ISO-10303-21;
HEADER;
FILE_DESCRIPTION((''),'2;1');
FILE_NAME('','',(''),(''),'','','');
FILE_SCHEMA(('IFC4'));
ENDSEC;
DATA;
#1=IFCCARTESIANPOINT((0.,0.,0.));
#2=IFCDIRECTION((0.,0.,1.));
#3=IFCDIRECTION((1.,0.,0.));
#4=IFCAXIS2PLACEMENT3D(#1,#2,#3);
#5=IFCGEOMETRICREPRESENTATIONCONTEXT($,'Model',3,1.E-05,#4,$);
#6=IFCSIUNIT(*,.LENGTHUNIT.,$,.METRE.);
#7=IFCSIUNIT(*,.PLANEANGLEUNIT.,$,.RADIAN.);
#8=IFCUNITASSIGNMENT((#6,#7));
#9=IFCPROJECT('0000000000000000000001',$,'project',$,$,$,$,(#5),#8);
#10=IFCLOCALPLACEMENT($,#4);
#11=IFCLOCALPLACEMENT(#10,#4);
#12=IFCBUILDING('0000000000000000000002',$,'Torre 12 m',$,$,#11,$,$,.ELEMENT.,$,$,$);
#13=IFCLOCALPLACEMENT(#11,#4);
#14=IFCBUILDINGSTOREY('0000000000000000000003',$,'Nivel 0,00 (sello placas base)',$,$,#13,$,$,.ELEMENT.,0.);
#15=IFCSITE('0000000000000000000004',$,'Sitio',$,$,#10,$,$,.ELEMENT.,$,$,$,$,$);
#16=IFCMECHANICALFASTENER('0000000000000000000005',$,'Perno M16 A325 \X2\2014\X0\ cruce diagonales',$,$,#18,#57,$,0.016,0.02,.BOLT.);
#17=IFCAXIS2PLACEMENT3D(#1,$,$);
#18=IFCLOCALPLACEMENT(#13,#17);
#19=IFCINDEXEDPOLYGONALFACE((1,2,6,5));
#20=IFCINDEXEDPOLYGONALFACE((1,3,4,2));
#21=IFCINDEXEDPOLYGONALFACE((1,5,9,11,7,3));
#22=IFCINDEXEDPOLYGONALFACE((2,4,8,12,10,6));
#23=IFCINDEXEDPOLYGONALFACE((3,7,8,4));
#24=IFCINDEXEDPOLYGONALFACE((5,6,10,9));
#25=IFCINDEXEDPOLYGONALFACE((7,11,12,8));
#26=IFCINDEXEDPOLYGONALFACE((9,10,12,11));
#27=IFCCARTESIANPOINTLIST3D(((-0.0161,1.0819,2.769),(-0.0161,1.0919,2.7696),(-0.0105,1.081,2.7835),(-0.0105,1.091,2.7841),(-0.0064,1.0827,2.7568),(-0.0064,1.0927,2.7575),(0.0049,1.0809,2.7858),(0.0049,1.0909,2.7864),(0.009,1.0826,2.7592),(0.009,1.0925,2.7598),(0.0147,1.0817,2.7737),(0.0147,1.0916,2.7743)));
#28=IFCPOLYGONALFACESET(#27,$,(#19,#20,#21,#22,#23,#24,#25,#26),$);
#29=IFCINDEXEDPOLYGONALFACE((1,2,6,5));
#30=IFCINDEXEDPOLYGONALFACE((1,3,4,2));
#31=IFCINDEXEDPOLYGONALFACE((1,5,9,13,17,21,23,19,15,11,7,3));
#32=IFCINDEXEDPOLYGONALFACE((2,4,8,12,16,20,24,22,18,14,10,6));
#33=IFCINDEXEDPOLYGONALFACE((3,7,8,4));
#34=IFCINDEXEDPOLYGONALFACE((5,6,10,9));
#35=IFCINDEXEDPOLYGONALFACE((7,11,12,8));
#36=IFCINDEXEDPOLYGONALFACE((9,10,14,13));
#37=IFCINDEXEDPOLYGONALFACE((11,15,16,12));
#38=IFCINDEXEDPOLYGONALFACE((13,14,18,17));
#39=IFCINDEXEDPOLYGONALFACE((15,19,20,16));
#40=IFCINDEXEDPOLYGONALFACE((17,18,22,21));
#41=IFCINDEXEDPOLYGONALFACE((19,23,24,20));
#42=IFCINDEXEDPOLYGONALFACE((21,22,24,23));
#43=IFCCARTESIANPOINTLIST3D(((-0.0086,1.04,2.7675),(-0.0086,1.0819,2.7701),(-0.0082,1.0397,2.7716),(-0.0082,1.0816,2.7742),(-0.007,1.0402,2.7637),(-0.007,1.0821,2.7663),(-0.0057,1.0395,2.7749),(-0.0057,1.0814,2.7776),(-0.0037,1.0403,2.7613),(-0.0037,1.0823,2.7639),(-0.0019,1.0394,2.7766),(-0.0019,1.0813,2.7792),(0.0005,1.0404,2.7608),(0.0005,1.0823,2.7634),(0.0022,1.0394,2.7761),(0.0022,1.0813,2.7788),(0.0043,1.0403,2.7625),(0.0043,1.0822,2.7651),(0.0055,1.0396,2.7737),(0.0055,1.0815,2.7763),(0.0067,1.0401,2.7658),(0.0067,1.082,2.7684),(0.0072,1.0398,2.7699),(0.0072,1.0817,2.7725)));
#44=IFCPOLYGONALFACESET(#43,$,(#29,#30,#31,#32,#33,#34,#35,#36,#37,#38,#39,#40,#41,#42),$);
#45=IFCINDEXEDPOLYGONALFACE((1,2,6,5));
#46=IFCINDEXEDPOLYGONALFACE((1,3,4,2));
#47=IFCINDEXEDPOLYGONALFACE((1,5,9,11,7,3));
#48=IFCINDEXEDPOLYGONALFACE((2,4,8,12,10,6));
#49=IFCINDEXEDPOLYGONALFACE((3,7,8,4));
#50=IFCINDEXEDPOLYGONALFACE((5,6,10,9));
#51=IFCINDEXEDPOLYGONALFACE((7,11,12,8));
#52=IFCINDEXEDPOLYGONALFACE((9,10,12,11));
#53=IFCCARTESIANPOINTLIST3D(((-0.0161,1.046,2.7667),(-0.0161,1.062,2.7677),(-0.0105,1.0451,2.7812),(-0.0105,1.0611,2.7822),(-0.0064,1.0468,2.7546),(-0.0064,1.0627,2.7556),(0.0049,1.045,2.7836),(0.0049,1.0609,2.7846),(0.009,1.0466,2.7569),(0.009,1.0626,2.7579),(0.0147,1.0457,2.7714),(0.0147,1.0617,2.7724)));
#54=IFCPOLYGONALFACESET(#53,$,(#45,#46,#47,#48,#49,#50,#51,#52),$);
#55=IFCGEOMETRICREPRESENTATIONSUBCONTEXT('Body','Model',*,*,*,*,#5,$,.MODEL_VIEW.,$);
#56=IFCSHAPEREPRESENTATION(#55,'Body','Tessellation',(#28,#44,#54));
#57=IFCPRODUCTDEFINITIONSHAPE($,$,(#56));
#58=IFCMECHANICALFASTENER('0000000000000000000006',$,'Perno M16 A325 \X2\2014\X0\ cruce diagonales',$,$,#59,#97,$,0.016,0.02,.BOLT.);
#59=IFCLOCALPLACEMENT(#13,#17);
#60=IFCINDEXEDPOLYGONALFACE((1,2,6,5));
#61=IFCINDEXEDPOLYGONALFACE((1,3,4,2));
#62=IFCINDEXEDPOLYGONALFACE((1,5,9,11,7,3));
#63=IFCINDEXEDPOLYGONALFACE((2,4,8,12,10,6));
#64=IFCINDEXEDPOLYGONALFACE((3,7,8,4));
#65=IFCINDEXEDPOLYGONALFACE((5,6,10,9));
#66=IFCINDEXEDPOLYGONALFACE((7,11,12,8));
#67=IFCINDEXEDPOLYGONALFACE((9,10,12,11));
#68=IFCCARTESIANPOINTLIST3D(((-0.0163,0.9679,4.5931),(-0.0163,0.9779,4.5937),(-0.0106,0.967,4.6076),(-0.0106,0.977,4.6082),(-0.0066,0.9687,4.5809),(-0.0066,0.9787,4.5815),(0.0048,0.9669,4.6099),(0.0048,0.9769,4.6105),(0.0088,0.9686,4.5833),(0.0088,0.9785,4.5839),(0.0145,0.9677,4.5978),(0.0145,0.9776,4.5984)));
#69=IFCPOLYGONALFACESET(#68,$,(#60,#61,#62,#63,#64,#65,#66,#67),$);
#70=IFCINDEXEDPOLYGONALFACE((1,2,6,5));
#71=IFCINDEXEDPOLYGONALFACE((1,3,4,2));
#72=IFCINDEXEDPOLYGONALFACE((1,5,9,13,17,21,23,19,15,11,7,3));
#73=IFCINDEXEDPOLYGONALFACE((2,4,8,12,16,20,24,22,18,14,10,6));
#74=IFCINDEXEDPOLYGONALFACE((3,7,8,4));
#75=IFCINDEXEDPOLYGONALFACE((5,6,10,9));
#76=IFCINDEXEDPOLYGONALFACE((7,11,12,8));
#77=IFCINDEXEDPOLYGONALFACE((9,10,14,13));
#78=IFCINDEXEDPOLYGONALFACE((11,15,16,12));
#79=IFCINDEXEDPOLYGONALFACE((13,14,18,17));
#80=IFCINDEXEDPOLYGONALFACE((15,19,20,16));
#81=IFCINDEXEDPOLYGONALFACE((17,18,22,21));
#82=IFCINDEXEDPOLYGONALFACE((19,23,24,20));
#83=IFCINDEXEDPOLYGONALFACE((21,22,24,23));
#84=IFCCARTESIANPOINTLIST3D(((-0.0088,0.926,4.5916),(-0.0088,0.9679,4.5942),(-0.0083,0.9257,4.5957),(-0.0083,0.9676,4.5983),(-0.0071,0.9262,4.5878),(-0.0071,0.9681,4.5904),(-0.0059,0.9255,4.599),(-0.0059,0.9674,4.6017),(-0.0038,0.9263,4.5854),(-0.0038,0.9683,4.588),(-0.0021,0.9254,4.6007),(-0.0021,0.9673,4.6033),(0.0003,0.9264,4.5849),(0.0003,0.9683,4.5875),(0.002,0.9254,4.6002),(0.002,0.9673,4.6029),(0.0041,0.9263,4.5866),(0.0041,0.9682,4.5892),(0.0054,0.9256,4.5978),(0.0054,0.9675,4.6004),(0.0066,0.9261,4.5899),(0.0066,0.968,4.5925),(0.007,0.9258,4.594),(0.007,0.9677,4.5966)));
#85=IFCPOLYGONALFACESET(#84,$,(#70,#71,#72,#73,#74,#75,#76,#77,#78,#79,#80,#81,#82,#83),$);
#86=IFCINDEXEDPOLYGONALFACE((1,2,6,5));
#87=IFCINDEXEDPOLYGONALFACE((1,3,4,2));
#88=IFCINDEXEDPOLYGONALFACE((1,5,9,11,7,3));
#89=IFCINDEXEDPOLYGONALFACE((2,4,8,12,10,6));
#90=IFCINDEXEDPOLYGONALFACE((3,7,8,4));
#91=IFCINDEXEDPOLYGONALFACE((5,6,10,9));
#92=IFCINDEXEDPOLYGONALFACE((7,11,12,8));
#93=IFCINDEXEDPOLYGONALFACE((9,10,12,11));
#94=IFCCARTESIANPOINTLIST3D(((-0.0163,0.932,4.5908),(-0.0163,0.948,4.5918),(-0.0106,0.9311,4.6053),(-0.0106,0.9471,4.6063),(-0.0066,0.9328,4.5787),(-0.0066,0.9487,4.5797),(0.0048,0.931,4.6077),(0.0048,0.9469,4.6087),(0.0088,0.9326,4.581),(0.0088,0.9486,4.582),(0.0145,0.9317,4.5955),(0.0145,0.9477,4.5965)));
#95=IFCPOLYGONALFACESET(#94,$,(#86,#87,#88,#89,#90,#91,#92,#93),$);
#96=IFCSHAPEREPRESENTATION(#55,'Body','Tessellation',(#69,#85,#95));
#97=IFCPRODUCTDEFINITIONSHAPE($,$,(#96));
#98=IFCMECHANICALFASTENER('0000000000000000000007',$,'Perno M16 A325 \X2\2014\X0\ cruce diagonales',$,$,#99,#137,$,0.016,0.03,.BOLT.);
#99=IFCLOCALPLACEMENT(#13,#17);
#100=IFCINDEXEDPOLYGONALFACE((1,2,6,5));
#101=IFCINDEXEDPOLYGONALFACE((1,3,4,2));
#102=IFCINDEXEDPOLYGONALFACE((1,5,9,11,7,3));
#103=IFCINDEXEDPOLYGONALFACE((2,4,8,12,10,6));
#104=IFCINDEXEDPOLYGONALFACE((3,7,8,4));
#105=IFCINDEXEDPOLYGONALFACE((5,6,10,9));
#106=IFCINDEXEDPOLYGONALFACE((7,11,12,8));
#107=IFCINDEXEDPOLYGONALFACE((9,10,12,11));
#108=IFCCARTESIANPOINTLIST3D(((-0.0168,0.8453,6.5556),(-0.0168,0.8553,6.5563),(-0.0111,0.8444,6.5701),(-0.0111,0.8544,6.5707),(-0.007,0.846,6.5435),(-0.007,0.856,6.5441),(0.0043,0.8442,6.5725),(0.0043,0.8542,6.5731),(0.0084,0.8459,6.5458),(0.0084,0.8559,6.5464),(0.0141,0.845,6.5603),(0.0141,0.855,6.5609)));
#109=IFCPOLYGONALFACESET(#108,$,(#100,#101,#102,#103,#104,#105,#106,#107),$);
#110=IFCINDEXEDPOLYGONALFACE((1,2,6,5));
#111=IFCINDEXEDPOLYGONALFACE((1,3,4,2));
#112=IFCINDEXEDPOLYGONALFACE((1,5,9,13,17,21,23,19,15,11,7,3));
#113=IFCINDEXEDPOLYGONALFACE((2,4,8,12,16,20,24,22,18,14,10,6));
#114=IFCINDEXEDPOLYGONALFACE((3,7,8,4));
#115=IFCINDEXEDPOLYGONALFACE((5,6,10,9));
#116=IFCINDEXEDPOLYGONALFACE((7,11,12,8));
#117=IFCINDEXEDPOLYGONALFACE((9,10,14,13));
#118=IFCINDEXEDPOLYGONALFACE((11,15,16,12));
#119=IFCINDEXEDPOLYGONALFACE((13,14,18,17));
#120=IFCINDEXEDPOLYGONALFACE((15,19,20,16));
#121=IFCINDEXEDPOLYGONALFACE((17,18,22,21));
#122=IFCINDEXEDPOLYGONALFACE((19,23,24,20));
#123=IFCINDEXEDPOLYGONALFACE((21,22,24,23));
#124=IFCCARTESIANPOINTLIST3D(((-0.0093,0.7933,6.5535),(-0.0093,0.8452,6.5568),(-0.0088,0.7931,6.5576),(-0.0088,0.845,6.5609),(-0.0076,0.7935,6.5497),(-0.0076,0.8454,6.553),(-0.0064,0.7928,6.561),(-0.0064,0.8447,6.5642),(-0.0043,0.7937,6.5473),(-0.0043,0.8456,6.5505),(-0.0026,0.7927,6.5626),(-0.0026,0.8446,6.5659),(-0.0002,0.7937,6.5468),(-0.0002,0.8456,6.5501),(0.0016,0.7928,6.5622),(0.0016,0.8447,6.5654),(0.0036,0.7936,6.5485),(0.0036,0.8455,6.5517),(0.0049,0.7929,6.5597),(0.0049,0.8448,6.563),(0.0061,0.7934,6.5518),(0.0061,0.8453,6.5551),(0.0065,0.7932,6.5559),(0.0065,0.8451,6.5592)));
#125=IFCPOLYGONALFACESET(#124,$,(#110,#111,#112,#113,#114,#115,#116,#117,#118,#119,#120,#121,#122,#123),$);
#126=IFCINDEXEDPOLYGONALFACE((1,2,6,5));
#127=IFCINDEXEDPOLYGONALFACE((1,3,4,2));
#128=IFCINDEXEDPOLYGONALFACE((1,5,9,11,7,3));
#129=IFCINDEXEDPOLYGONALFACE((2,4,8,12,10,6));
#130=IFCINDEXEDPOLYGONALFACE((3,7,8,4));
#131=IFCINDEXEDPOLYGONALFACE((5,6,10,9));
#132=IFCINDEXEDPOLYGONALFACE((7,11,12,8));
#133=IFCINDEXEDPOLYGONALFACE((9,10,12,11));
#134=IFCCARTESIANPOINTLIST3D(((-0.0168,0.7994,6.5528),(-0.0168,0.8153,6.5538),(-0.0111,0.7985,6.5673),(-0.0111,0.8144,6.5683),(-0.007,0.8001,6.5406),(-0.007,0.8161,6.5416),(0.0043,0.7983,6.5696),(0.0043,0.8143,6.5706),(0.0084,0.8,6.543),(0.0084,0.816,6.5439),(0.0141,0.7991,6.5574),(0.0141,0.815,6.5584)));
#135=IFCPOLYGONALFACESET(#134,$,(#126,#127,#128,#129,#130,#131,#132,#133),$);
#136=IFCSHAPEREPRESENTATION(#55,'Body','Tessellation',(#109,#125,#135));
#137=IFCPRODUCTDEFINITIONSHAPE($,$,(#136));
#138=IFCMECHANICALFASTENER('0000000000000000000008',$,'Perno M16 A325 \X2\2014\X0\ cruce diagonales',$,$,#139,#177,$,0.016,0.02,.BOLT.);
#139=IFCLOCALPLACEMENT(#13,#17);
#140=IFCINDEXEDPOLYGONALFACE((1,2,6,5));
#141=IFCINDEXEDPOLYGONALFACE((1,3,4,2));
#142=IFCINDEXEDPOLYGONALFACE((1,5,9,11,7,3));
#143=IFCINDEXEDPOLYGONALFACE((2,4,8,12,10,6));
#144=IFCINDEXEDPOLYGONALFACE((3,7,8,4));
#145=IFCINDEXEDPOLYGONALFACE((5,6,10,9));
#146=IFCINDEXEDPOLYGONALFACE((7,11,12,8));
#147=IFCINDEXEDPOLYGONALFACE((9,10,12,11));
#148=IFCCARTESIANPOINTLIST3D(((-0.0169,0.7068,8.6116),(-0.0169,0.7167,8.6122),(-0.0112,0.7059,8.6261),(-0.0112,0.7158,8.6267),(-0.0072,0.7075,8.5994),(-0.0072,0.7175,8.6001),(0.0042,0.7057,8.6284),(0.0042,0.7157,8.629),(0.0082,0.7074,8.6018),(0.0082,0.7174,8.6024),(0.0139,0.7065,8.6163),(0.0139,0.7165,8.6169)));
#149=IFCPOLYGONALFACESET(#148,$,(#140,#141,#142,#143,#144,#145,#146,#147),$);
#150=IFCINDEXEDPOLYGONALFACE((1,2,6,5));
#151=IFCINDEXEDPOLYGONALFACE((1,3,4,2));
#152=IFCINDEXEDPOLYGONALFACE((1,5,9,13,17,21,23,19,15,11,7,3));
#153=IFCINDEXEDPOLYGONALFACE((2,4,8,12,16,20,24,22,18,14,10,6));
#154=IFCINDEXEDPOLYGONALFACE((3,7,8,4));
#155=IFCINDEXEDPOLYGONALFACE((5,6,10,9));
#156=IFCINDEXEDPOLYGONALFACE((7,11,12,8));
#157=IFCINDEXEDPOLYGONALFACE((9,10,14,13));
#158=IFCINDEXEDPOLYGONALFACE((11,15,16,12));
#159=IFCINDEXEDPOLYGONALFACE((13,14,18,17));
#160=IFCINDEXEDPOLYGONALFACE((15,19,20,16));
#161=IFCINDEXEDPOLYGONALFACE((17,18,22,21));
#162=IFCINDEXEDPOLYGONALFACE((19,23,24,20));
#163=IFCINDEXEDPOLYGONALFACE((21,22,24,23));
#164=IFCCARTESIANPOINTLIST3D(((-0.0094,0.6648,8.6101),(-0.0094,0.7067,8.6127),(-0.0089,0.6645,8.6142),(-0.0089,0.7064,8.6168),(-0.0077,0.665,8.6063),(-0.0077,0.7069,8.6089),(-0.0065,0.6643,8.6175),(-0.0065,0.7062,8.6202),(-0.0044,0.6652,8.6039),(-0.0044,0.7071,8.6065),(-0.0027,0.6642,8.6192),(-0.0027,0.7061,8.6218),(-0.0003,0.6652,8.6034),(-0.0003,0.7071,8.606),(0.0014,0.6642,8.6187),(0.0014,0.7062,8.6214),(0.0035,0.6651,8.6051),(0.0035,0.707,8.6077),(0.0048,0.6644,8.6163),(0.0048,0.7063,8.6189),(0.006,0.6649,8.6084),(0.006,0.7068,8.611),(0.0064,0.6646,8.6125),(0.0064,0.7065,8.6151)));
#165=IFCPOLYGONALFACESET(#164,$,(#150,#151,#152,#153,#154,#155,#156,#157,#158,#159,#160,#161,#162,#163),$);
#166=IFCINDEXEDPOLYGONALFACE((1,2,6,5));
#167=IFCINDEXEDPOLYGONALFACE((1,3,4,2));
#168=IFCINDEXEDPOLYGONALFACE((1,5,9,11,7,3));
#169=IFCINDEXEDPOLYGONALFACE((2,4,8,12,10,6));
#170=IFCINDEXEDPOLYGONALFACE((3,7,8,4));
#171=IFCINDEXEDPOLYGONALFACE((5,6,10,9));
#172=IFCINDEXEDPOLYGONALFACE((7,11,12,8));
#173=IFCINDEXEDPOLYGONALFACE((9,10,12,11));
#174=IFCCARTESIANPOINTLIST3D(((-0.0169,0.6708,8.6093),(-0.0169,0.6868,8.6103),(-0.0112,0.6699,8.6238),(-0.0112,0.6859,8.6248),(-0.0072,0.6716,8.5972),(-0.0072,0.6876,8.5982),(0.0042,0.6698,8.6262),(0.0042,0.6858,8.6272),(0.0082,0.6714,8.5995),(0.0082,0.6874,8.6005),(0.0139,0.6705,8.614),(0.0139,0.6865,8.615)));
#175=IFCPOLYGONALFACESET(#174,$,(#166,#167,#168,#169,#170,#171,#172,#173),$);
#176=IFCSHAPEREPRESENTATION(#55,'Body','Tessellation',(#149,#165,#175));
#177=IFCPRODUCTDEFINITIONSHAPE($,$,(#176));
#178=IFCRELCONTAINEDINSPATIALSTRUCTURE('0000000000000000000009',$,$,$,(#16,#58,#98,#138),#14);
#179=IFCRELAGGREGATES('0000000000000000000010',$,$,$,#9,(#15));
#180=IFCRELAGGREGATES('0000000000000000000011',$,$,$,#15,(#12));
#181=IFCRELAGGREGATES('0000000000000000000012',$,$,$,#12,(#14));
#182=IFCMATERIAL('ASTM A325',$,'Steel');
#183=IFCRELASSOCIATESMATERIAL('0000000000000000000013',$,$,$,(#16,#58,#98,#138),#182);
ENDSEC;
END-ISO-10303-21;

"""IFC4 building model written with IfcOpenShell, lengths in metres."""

from ifc_helpers import new_model, si_unit, frame, origin_with_axes, place, context, subcontext, project, spatial, polyline, outline, extrude, material, element, save


model = new_model("IFC4")

# Units and contexts
model_context = context("Model", 3, precision=1e-05, world=origin_with_axes())
body_context = subcontext(model_context, "Body", "Model", "MODEL_VIEW")
ifc_project = project(units=[si_unit("LENGTHUNIT", "METRE"), si_unit("PLANEANGLEUNIT", "RADIAN")], contexts=[model_context])

# Site, building, storey
site_placement = place(None, origin_with_axes())
site = spatial("IfcSite", under=ifc_project, at=site_placement, Name="Sitio", CompositionType="ELEMENT")
building_placement = place(site_placement, origin_with_axes())
building = spatial("IfcBuilding", under=site, at=building_placement, Name="Torre 12 m", CompositionType="ELEMENT")
storey_placement = place(building_placement, origin_with_axes())
storey = spatial("IfcBuildingStorey", under=building, at=storey_placement, Name="Nivel 0,00 (sello placas base)", CompositionType="ELEMENT", Elevation=0.0)

# Shared definitions
placement = place(storey_placement, origin_with_axes())

# Mechanical fasteners
ifc_material_1 = material(Name="ASTM A325", Category="Steel")
element("IfcMechanicalFastener", 1, at=placement, inside=storey, material=ifc_material_1, Name="Perno M16 A325 — cruce diagonales", NominalDiameter=0.016, NominalLength=0.02, PredefinedType="BOLT", context=body_context, shape_type="SweptSolid", body=[
    extrude(outline(polyline([(0.0135, 0.0078), (0.0, 0.0156), (-0.0135, 0.0078), (-0.0135, -0.0078), (0.0, -0.0156), (0.0135, -0.0078), (0.0135, 0.0078)])), frame((-0.0007, 1.0918, 2.7719), z_axis=(0.0, -0.998053, -0.062378), x_axis=(-0.931337, -0.022716, 0.363449)), (0.0, 0.0, 1.0), 0.01),
    extrude(outline(polyline([(0.008, 0.0), (0.0069, 0.004), (0.004, 0.0069), (0.0, 0.008), (-0.004, 0.0069), (-0.0069, 0.004), (-0.008, 0.0), (-0.0069, -0.004), (-0.004, -0.0069), (0.0, -0.008), (0.004, -0.0069), (0.0069, -0.004), (0.008, 0.0)])), frame((-0.0007, 1.0818, 2.7713), z_axis=(0.0, -0.998053, -0.062378), x_axis=(-0.931337, -0.022716, 0.363449)), (0.0, 0.0, 1.0), 0.042),
    extrude(outline(polyline([(0.0135, 0.0078), (0.0, 0.0156), (-0.0135, 0.0078), (-0.0135, -0.0078), (0.0, -0.0156), (0.0135, -0.0078), (0.0135, 0.0078)])), frame((-0.0007, 1.0618, 2.7701), z_axis=(0.0, -0.998053, -0.062378), x_axis=(-0.931337, -0.022716, 0.363449)), (0.0, 0.0, 1.0), 0.016),
])
element("IfcMechanicalFastener", 2, at=placement, inside=storey, material=ifc_material_1, Name="Perno M16 A325 — cruce diagonales", NominalDiameter=0.016, NominalLength=0.02, PredefinedType="BOLT", context=body_context, shape_type="SweptSolid", body=[
    extrude(outline(polyline([(0.0135, 0.0078), (0.0, 0.0156), (-0.0135, 0.0078), (-0.0135, -0.0078), (0.0, -0.0156), (0.0135, -0.0078), (0.0135, 0.0078)])), frame((-0.0009, 0.9778, 4.596), z_axis=(0.0, -0.998053, -0.062378), x_axis=(-0.931337, -0.022716, 0.363449)), (0.0, 0.0, 1.0), 0.01),
    extrude(outline(polyline([(0.008, 0.0), (0.0069, 0.004), (0.004, 0.0069), (0.0, 0.008), (-0.004, 0.0069), (-0.0069, 0.004), (-0.008, 0.0), (-0.0069, -0.004), (-0.004, -0.0069), (0.0, -0.008), (0.004, -0.0069), (0.0069, -0.004), (0.008, 0.0)])), frame((-0.0009, 0.9678, 4.5954), z_axis=(0.0, -0.998053, -0.062378), x_axis=(-0.931337, -0.022716, 0.363449)), (0.0, 0.0, 1.0), 0.042),
    extrude(outline(polyline([(0.0135, 0.0078), (0.0, 0.0156), (-0.0135, 0.0078), (-0.0135, -0.0078), (0.0, -0.0156), (0.0135, -0.0078), (0.0135, 0.0078)])), frame((-0.0009, 0.9478, 4.5942), z_axis=(0.0, -0.998053, -0.062378), x_axis=(-0.931337, -0.022716, 0.363449)), (0.0, 0.0, 1.0), 0.016),
])
element("IfcMechanicalFastener", 3, at=placement, inside=storey, material=ifc_material_1, Name="Perno M16 A325 — cruce diagonales", NominalDiameter=0.016, NominalLength=0.03, PredefinedType="BOLT", context=body_context, shape_type="SweptSolid", body=[
    extrude(outline(polyline([(0.0135, 0.0078), (0.0, 0.0156), (-0.0135, 0.0078), (-0.0135, -0.0078), (0.0, -0.0156), (0.0135, -0.0078), (0.0135, 0.0078)])), frame((-0.0014, 0.8551, 6.5586), z_axis=(0.0, -0.998053, -0.062378), x_axis=(-0.931337, -0.022716, 0.363449)), (0.0, 0.0, 1.0), 0.01),
    extrude(outline(polyline([(0.008, 0.0), (0.0069, 0.004), (0.004, 0.0069), (0.0, 0.008), (-0.004, 0.0069), (-0.0069, 0.004), (-0.008, 0.0), (-0.0069, -0.004), (-0.004, -0.0069), (0.0, -0.008), (0.004, -0.0069), (0.0069, -0.004), (0.008, 0.0)])), frame((-0.0014, 0.8451, 6.558), z_axis=(0.0, -0.998053, -0.062378), x_axis=(-0.931337, -0.022716, 0.363449)), (0.0, 0.0, 1.0), 0.052),
    extrude(outline(polyline([(0.0135, 0.0078), (0.0, 0.0156), (-0.0135, 0.0078), (-0.0135, -0.0078), (0.0, -0.0156), (0.0135, -0.0078), (0.0135, 0.0078)])), frame((-0.0014, 0.8152, 6.5561), z_axis=(0.0, -0.998053, -0.062378), x_axis=(-0.931337, -0.022716, 0.363449)), (0.0, 0.0, 1.0), 0.016),
])
element("IfcMechanicalFastener", 4, at=placement, inside=storey, material=ifc_material_1, Name="Perno M16 A325 — cruce diagonales", NominalDiameter=0.016, NominalLength=0.02, PredefinedType="BOLT", context=body_context, shape_type="SweptSolid", body=[
    extrude(outline(polyline([(0.0135, 0.0078), (0.0, 0.0156), (-0.0135, 0.0078), (-0.0135, -0.0078), (0.0, -0.0156), (0.0135, -0.0078), (0.0135, 0.0078)])), frame((-0.0015, 0.7166, 8.6145), z_axis=(0.0, -0.998053, -0.062378), x_axis=(-0.931337, -0.022716, 0.363449)), (0.0, 0.0, 1.0), 0.01),
    extrude(outline(polyline([(0.008, 0.0), (0.0069, 0.004), (0.004, 0.0069), (0.0, 0.008), (-0.004, 0.0069), (-0.0069, 0.004), (-0.008, 0.0), (-0.0069, -0.004), (-0.004, -0.0069), (0.0, -0.008), (0.004, -0.0069), (0.0069, -0.004), (0.008, 0.0)])), frame((-0.0015, 0.7066, 8.6139), z_axis=(0.0, -0.998053, -0.062378), x_axis=(-0.931337, -0.022716, 0.363449)), (0.0, 0.0, 1.0), 0.042),
    extrude(outline(polyline([(0.0135, 0.0078), (0.0, 0.0156), (-0.0135, 0.0078), (-0.0135, -0.0078), (0.0, -0.0156), (0.0135, -0.0078), (0.0135, 0.0078)])), frame((-0.0015, 0.6867, 8.6127), z_axis=(0.0, -0.998053, -0.062378), x_axis=(-0.931337, -0.022716, 0.363449)), (0.0, 0.0, 1.0), 0.016),
])

save(model, "model.ifc")
